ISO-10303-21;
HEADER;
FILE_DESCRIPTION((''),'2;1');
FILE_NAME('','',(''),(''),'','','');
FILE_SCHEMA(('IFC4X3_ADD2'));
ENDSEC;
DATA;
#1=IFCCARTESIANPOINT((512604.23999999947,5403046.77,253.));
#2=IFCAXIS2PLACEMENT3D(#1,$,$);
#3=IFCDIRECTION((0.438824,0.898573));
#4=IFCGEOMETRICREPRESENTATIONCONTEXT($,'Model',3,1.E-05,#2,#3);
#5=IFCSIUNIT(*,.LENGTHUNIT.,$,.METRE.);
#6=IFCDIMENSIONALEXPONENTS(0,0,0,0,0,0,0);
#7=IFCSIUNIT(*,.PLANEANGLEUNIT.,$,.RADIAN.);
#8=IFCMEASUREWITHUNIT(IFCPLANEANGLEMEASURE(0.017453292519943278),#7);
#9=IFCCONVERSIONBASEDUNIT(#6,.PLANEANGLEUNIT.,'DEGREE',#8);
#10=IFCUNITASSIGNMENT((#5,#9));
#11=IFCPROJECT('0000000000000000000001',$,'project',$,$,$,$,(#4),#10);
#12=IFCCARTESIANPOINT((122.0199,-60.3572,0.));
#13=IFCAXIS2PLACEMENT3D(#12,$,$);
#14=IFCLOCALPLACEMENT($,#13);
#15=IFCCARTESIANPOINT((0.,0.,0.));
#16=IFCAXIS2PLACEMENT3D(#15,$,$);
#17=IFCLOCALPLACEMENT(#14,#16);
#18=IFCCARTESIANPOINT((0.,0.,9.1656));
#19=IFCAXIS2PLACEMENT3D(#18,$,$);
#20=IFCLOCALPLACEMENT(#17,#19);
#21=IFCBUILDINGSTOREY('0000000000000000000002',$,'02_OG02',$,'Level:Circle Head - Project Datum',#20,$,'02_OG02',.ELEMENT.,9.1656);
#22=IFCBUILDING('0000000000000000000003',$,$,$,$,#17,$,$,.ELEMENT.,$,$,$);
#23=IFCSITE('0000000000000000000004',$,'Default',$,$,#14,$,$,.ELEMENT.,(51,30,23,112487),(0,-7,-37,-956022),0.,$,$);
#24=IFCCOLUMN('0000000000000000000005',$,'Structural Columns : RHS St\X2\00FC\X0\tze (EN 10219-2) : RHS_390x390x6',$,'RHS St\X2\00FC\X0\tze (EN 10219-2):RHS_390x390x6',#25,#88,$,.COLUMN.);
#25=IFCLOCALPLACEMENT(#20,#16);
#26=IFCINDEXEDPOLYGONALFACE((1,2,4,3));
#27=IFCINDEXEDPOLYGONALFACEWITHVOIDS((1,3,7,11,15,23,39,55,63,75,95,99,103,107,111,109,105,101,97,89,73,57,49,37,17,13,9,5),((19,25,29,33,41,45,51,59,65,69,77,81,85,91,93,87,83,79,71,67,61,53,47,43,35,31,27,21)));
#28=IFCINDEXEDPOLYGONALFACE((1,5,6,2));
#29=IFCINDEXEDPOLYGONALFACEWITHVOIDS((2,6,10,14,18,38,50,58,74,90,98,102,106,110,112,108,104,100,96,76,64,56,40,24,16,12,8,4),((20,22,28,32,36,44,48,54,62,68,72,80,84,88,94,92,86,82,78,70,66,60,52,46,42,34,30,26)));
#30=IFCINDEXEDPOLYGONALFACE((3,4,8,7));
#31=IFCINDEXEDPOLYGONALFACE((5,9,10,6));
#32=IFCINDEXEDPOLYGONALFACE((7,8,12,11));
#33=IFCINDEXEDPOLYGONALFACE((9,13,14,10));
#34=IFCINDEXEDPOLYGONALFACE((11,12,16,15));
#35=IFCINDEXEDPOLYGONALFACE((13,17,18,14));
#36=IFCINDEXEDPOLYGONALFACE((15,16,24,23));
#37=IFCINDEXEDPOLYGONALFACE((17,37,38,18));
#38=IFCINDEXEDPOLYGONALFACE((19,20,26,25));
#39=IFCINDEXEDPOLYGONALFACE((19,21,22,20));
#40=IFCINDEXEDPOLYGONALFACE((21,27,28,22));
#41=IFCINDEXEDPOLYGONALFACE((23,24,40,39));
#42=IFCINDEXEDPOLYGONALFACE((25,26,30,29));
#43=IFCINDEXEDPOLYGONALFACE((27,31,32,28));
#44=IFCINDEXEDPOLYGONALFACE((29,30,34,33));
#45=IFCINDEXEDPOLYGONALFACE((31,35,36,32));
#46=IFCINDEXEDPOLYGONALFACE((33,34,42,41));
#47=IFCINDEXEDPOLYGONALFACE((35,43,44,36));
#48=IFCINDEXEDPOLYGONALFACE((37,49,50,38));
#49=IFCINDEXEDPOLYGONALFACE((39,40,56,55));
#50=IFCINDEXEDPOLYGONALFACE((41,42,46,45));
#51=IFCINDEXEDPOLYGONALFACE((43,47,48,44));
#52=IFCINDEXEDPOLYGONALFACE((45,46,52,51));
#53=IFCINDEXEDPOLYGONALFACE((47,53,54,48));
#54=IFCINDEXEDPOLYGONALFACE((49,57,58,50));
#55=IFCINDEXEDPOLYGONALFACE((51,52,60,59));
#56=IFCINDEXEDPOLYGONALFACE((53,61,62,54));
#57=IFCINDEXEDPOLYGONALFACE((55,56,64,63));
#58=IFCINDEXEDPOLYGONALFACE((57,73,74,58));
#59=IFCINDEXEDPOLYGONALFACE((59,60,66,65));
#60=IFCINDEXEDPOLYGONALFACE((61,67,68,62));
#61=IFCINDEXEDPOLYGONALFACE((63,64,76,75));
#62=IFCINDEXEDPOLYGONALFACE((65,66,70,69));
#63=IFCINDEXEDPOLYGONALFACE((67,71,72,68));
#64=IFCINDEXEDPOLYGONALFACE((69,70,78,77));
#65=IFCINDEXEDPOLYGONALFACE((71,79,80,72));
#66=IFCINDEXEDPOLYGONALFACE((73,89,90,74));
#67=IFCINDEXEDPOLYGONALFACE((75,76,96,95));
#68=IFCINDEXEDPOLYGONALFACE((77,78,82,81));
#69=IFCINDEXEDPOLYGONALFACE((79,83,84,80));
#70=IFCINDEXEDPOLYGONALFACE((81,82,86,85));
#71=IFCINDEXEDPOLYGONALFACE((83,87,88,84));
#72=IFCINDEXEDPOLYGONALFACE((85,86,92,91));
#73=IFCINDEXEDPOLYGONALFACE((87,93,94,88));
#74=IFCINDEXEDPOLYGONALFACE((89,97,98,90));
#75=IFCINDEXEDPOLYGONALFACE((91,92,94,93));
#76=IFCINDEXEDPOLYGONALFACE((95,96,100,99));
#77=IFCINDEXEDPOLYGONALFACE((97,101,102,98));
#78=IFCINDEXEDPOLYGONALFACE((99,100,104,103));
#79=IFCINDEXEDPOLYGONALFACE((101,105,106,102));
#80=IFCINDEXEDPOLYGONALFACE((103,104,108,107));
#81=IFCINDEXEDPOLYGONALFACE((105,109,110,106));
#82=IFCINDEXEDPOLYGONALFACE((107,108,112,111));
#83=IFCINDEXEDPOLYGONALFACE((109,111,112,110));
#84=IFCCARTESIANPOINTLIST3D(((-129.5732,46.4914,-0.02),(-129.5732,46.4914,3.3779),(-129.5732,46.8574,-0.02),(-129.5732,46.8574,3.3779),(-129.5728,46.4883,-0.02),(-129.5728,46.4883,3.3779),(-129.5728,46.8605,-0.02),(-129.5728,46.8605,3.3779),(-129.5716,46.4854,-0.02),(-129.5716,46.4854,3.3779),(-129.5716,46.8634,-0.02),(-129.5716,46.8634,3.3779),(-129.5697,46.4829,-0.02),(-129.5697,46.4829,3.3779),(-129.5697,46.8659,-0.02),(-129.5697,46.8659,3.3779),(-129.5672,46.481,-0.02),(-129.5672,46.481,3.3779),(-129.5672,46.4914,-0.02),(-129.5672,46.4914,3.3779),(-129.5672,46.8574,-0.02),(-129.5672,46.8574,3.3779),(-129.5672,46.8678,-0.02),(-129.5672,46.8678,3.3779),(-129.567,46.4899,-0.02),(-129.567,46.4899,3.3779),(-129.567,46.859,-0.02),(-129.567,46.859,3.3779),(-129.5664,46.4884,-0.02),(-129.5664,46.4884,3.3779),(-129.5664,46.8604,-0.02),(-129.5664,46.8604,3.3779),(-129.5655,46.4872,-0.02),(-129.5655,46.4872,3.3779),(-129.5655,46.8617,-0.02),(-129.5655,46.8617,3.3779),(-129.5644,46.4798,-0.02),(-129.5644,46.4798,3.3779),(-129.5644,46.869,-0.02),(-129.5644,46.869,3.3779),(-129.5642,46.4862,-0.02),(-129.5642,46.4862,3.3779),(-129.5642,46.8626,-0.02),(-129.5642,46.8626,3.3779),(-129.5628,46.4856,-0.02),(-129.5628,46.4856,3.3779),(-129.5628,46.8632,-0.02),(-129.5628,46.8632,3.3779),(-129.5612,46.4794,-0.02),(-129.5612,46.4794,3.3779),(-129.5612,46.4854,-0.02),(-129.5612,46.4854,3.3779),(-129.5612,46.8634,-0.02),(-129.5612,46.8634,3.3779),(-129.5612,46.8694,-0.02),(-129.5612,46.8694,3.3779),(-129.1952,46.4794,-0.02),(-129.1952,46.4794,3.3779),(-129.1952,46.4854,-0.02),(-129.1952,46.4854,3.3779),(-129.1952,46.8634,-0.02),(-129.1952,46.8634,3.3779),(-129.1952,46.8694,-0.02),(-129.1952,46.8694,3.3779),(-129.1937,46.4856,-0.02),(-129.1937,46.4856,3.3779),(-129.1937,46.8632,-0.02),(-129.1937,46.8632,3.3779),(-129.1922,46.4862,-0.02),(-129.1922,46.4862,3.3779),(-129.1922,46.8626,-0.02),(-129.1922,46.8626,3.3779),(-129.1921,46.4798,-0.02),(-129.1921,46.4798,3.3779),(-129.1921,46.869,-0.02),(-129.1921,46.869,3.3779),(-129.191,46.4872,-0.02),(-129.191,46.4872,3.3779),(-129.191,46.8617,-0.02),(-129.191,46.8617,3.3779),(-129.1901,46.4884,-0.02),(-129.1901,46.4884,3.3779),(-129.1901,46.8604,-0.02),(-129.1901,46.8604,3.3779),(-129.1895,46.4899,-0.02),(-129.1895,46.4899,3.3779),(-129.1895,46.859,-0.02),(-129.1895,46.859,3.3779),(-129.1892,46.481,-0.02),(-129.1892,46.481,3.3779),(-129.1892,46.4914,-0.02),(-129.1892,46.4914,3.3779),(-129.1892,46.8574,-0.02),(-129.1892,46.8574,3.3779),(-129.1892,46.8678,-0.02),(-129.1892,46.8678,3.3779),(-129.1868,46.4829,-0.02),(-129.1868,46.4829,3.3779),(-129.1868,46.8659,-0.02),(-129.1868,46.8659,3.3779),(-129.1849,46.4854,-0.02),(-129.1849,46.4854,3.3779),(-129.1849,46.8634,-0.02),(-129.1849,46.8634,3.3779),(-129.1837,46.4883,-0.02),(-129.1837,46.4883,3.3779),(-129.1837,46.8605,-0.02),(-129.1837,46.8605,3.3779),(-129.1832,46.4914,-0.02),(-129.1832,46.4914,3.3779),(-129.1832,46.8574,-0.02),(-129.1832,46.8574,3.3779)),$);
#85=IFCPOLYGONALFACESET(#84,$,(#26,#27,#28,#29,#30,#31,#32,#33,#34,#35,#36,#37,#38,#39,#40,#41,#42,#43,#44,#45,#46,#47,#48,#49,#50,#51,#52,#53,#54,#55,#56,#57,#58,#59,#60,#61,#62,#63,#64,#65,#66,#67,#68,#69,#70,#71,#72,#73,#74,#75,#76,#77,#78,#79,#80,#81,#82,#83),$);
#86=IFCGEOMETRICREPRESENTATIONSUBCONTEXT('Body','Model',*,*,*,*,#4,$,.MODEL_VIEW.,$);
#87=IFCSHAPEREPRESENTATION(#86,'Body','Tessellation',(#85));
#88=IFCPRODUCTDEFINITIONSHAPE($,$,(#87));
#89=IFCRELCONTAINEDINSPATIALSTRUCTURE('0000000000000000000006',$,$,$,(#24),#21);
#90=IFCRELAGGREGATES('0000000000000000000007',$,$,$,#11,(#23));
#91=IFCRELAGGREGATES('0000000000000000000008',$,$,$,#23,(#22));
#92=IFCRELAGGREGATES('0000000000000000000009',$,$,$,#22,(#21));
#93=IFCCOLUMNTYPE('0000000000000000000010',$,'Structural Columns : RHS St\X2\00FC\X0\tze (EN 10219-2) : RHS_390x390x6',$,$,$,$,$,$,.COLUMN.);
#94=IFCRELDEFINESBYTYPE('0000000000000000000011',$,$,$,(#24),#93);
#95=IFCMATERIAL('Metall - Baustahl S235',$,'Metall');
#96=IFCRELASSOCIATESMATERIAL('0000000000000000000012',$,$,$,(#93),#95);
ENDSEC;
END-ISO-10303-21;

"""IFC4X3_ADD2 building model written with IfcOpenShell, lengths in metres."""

from ifc_helpers import new_model, entity, si_unit, converted_unit, direction, frame, frame_2d, origin, place, context, subcontext, project, spatial, polyline, circle_curve, parameter, trimmed, segment, composite_curve, outline, extrude, source, transform, mapped, material, material_profile, profile_set, type_object, type_shapes, element, save


model = new_model("IFC4X3_ADD2")

# Units and contexts
model_context = context("Model", 3, precision=1e-05, world=frame((512604.23999999947, 5403046.77, 253.0)), true_north=direction((0.438824, 0.898573)))
body_context = subcontext(model_context, "Body", "Model", "MODEL_VIEW")
ifc_project = project(units=[si_unit("LENGTHUNIT", "METRE"), converted_unit("PLANEANGLEUNIT", "DEGREE", entity("IfcPlaneAngleMeasure", 0.017453292519943278), si_unit("PLANEANGLEUNIT", "RADIAN"), dimensions=[0, 0, 0, 0, 0, 0, 0])], contexts=[model_context])

# Site, building, storey
site_placement = place(None, frame((122.0199, -60.3572, 0.0)))
site = spatial("IfcSite", under=ifc_project, at=site_placement, Name="Default", CompositionType="ELEMENT", RefLatitude=(51, 30, 23, 112487), RefLongitude=(0, -7, -37, -956022), RefElevation=0.0)
building_placement = place(site_placement, origin())
building = spatial("IfcBuilding", under=site, at=building_placement, CompositionType="ELEMENT")
storey_placement = place(building_placement, frame((0.0, 0.0, 9.1656)))
storey = spatial("IfcBuildingStorey", under=building, at=storey_placement, Name="02_OG02", ObjectType="Level:Circle Head - Project Datum", LongName="02_OG02", CompositionType="ELEMENT", Elevation=9.1656)

# Column
ifc_material_1 = material(Name="Metall - Baustahl S235", Category="Metall")
ifc_material_profile = material_profile(ifc_material_1, outline(composite_curve([segment(polyline([(-0.183, -0.195), (0.183, -0.195)]), True, "CONTINUOUS"), segment(trimmed(circle_curve(frame_2d((0.183, -0.183), x_axis=(-1.0, 0.0)), 0.012), [parameter(90.0)], [parameter(180.0)], True, "PARAMETER"), True, "CONTINUOUS"), segment(polyline([(0.195, -0.183), (0.195, 0.183)]), True, "CONTINUOUS"), segment(trimmed(circle_curve(frame_2d((0.183, 0.183), x_axis=(-1.0, 0.0)), 0.012), [parameter(180.0)], [parameter(270.0)], True, "PARAMETER"), True, "CONTINUOUS"), segment(polyline([(0.183, 0.195), (-0.183, 0.195)]), True, "CONTINUOUS"), segment(trimmed(circle_curve(frame_2d((-0.183, 0.183), x_axis=(-1.0, 0.0)), 0.012), [parameter(270.0)], [parameter(360.0)], True, "PARAMETER"), True, "CONTINUOUS"), segment(polyline([(-0.195, 0.183), (-0.195, -0.183)]), True, "CONTINUOUS"), segment(trimmed(circle_curve(frame_2d((-0.183, -0.183), x_axis=(-1.0, 0.0)), 0.012), [parameter(360.0)], [parameter(90.0)], True, "PARAMETER"), True, "CONTINUOUS")], self_intersect=False), holes=[composite_curve([segment(trimmed(circle_curve(frame_2d((-0.183, -0.183), x_axis=(-1.0, 0.0)), 0.006), [parameter(0.0)], [parameter(90.0)], True, "PARAMETER"), False, "CONTINUOUS"), segment(polyline([(-0.189, -0.183), (-0.189, 0.183)]), True, "CONTINUOUS"), segment(trimmed(circle_curve(frame_2d((-0.183, 0.183), x_axis=(-1.0, 0.0)), 0.006), [parameter(270.0)], [parameter(0.0)], True, "PARAMETER"), False, "CONTINUOUS"), segment(polyline([(-0.183, 0.189), (0.183, 0.189)]), True, "CONTINUOUS"), segment(trimmed(circle_curve(frame_2d((0.183, 0.183), x_axis=(-1.0, 0.0)), 0.006), [parameter(180.0)], [parameter(270.0)], True, "PARAMETER"), False, "CONTINUOUS"), segment(polyline([(0.189, 0.183), (0.189, -0.183)]), True, "CONTINUOUS"), segment(trimmed(circle_curve(frame_2d((0.183, -0.183), x_axis=(-1.0, 0.0)), 0.006), [parameter(90.0)], [parameter(180.0)], True, "PARAMETER"), False, "CONTINUOUS"), segment(polyline([(0.183, -0.189), (-0.183, -0.189)]), True, "CONTINUOUS")], self_intersect=False)]), Name="RHS_390x390x6")
ifc_profile_set = profile_set([ifc_material_profile], Name="RHS_390x390x6")
column_type_1 = type_object("IfcColumnType", Name="Structural Columns : RHS Stütze (EN 10219-2) : RHS_390x390x6", PredefinedType="COLUMN", material=ifc_profile_set)
shared_shape_1 = source(origin(), body_context, "Body", "SweptSolid", [
    extrude(outline(composite_curve([segment(polyline([(-0.183, -0.195), (0.183, -0.195)]), True, "CONTINUOUS"), segment(trimmed(circle_curve(frame_2d((0.183, -0.183), x_axis=(-1.0, 0.0)), 0.012), [parameter(90.0)], [parameter(180.0)], True, "PARAMETER"), True, "CONTINUOUS"), segment(polyline([(0.195, -0.183), (0.195, 0.183)]), True, "CONTINUOUS"), segment(trimmed(circle_curve(frame_2d((0.183, 0.183), x_axis=(-1.0, 0.0)), 0.012), [parameter(180.0)], [parameter(270.0)], True, "PARAMETER"), True, "CONTINUOUS"), segment(polyline([(0.183, 0.195), (-0.183, 0.195)]), True, "CONTINUOUS"), segment(trimmed(circle_curve(frame_2d((-0.183, 0.183), x_axis=(-1.0, 0.0)), 0.012), [parameter(270.0)], [parameter(360.0)], True, "PARAMETER"), True, "CONTINUOUS"), segment(polyline([(-0.195, 0.183), (-0.195, -0.183)]), True, "CONTINUOUS"), segment(trimmed(circle_curve(frame_2d((-0.183, -0.183), x_axis=(-1.0, 0.0)), 0.012), [parameter(360.0)], [parameter(90.0)], True, "PARAMETER"), True, "CONTINUOUS")], self_intersect=False), holes=[composite_curve([segment(trimmed(circle_curve(frame_2d((-0.183, -0.183), x_axis=(-1.0, 0.0)), 0.006), [parameter(0.0)], [parameter(90.0)], True, "PARAMETER"), False, "CONTINUOUS"), segment(polyline([(-0.189, -0.183), (-0.189, 0.183)]), True, "CONTINUOUS"), segment(trimmed(circle_curve(frame_2d((-0.183, 0.183), x_axis=(-1.0, 0.0)), 0.006), [parameter(270.0)], [parameter(0.0)], True, "PARAMETER"), False, "CONTINUOUS"), segment(polyline([(-0.183, 0.189), (0.183, 0.189)]), True, "CONTINUOUS"), segment(trimmed(circle_curve(frame_2d((0.183, 0.183), x_axis=(-1.0, 0.0)), 0.006), [parameter(180.0)], [parameter(270.0)], True, "PARAMETER"), False, "CONTINUOUS"), segment(polyline([(0.189, 0.183), (0.189, -0.183)]), True, "CONTINUOUS"), segment(trimmed(circle_curve(frame_2d((0.183, -0.183), x_axis=(-1.0, 0.0)), 0.006), [parameter(90.0)], [parameter(180.0)], True, "PARAMETER"), False, "CONTINUOUS"), segment(polyline([(0.183, -0.189), (-0.183, -0.189)]), True, "CONTINUOUS")], self_intersect=False)]), frame((0.0, 0.0, 9.1456), z_axis=(0.0, 0.0, 1.0), x_axis=(-1.0, 0.0, 0.0)), (0.0, 0.0, 1.0), 3.3979),
])
type_shapes(column_type_1, [shared_shape_1])
column_1_placement = place(storey_placement, frame((-129.3782, 46.6744, -9.1656)))
element("IfcColumn", 1, at=column_1_placement, inside=storey, type_object=column_type_1, Name="Structural Columns : RHS Stütze (EN 10219-2) : RHS_390x390x6", ObjectType="RHS Stütze (EN 10219-2):RHS_390x390x6", PredefinedType="COLUMN", context=body_context, shape_type="MappedRepresentation", body=[
    mapped(shared_shape_1, transform((0.0, 0.0, 0.0), scale=1.0)),
])

save(model, "model.ifc")
